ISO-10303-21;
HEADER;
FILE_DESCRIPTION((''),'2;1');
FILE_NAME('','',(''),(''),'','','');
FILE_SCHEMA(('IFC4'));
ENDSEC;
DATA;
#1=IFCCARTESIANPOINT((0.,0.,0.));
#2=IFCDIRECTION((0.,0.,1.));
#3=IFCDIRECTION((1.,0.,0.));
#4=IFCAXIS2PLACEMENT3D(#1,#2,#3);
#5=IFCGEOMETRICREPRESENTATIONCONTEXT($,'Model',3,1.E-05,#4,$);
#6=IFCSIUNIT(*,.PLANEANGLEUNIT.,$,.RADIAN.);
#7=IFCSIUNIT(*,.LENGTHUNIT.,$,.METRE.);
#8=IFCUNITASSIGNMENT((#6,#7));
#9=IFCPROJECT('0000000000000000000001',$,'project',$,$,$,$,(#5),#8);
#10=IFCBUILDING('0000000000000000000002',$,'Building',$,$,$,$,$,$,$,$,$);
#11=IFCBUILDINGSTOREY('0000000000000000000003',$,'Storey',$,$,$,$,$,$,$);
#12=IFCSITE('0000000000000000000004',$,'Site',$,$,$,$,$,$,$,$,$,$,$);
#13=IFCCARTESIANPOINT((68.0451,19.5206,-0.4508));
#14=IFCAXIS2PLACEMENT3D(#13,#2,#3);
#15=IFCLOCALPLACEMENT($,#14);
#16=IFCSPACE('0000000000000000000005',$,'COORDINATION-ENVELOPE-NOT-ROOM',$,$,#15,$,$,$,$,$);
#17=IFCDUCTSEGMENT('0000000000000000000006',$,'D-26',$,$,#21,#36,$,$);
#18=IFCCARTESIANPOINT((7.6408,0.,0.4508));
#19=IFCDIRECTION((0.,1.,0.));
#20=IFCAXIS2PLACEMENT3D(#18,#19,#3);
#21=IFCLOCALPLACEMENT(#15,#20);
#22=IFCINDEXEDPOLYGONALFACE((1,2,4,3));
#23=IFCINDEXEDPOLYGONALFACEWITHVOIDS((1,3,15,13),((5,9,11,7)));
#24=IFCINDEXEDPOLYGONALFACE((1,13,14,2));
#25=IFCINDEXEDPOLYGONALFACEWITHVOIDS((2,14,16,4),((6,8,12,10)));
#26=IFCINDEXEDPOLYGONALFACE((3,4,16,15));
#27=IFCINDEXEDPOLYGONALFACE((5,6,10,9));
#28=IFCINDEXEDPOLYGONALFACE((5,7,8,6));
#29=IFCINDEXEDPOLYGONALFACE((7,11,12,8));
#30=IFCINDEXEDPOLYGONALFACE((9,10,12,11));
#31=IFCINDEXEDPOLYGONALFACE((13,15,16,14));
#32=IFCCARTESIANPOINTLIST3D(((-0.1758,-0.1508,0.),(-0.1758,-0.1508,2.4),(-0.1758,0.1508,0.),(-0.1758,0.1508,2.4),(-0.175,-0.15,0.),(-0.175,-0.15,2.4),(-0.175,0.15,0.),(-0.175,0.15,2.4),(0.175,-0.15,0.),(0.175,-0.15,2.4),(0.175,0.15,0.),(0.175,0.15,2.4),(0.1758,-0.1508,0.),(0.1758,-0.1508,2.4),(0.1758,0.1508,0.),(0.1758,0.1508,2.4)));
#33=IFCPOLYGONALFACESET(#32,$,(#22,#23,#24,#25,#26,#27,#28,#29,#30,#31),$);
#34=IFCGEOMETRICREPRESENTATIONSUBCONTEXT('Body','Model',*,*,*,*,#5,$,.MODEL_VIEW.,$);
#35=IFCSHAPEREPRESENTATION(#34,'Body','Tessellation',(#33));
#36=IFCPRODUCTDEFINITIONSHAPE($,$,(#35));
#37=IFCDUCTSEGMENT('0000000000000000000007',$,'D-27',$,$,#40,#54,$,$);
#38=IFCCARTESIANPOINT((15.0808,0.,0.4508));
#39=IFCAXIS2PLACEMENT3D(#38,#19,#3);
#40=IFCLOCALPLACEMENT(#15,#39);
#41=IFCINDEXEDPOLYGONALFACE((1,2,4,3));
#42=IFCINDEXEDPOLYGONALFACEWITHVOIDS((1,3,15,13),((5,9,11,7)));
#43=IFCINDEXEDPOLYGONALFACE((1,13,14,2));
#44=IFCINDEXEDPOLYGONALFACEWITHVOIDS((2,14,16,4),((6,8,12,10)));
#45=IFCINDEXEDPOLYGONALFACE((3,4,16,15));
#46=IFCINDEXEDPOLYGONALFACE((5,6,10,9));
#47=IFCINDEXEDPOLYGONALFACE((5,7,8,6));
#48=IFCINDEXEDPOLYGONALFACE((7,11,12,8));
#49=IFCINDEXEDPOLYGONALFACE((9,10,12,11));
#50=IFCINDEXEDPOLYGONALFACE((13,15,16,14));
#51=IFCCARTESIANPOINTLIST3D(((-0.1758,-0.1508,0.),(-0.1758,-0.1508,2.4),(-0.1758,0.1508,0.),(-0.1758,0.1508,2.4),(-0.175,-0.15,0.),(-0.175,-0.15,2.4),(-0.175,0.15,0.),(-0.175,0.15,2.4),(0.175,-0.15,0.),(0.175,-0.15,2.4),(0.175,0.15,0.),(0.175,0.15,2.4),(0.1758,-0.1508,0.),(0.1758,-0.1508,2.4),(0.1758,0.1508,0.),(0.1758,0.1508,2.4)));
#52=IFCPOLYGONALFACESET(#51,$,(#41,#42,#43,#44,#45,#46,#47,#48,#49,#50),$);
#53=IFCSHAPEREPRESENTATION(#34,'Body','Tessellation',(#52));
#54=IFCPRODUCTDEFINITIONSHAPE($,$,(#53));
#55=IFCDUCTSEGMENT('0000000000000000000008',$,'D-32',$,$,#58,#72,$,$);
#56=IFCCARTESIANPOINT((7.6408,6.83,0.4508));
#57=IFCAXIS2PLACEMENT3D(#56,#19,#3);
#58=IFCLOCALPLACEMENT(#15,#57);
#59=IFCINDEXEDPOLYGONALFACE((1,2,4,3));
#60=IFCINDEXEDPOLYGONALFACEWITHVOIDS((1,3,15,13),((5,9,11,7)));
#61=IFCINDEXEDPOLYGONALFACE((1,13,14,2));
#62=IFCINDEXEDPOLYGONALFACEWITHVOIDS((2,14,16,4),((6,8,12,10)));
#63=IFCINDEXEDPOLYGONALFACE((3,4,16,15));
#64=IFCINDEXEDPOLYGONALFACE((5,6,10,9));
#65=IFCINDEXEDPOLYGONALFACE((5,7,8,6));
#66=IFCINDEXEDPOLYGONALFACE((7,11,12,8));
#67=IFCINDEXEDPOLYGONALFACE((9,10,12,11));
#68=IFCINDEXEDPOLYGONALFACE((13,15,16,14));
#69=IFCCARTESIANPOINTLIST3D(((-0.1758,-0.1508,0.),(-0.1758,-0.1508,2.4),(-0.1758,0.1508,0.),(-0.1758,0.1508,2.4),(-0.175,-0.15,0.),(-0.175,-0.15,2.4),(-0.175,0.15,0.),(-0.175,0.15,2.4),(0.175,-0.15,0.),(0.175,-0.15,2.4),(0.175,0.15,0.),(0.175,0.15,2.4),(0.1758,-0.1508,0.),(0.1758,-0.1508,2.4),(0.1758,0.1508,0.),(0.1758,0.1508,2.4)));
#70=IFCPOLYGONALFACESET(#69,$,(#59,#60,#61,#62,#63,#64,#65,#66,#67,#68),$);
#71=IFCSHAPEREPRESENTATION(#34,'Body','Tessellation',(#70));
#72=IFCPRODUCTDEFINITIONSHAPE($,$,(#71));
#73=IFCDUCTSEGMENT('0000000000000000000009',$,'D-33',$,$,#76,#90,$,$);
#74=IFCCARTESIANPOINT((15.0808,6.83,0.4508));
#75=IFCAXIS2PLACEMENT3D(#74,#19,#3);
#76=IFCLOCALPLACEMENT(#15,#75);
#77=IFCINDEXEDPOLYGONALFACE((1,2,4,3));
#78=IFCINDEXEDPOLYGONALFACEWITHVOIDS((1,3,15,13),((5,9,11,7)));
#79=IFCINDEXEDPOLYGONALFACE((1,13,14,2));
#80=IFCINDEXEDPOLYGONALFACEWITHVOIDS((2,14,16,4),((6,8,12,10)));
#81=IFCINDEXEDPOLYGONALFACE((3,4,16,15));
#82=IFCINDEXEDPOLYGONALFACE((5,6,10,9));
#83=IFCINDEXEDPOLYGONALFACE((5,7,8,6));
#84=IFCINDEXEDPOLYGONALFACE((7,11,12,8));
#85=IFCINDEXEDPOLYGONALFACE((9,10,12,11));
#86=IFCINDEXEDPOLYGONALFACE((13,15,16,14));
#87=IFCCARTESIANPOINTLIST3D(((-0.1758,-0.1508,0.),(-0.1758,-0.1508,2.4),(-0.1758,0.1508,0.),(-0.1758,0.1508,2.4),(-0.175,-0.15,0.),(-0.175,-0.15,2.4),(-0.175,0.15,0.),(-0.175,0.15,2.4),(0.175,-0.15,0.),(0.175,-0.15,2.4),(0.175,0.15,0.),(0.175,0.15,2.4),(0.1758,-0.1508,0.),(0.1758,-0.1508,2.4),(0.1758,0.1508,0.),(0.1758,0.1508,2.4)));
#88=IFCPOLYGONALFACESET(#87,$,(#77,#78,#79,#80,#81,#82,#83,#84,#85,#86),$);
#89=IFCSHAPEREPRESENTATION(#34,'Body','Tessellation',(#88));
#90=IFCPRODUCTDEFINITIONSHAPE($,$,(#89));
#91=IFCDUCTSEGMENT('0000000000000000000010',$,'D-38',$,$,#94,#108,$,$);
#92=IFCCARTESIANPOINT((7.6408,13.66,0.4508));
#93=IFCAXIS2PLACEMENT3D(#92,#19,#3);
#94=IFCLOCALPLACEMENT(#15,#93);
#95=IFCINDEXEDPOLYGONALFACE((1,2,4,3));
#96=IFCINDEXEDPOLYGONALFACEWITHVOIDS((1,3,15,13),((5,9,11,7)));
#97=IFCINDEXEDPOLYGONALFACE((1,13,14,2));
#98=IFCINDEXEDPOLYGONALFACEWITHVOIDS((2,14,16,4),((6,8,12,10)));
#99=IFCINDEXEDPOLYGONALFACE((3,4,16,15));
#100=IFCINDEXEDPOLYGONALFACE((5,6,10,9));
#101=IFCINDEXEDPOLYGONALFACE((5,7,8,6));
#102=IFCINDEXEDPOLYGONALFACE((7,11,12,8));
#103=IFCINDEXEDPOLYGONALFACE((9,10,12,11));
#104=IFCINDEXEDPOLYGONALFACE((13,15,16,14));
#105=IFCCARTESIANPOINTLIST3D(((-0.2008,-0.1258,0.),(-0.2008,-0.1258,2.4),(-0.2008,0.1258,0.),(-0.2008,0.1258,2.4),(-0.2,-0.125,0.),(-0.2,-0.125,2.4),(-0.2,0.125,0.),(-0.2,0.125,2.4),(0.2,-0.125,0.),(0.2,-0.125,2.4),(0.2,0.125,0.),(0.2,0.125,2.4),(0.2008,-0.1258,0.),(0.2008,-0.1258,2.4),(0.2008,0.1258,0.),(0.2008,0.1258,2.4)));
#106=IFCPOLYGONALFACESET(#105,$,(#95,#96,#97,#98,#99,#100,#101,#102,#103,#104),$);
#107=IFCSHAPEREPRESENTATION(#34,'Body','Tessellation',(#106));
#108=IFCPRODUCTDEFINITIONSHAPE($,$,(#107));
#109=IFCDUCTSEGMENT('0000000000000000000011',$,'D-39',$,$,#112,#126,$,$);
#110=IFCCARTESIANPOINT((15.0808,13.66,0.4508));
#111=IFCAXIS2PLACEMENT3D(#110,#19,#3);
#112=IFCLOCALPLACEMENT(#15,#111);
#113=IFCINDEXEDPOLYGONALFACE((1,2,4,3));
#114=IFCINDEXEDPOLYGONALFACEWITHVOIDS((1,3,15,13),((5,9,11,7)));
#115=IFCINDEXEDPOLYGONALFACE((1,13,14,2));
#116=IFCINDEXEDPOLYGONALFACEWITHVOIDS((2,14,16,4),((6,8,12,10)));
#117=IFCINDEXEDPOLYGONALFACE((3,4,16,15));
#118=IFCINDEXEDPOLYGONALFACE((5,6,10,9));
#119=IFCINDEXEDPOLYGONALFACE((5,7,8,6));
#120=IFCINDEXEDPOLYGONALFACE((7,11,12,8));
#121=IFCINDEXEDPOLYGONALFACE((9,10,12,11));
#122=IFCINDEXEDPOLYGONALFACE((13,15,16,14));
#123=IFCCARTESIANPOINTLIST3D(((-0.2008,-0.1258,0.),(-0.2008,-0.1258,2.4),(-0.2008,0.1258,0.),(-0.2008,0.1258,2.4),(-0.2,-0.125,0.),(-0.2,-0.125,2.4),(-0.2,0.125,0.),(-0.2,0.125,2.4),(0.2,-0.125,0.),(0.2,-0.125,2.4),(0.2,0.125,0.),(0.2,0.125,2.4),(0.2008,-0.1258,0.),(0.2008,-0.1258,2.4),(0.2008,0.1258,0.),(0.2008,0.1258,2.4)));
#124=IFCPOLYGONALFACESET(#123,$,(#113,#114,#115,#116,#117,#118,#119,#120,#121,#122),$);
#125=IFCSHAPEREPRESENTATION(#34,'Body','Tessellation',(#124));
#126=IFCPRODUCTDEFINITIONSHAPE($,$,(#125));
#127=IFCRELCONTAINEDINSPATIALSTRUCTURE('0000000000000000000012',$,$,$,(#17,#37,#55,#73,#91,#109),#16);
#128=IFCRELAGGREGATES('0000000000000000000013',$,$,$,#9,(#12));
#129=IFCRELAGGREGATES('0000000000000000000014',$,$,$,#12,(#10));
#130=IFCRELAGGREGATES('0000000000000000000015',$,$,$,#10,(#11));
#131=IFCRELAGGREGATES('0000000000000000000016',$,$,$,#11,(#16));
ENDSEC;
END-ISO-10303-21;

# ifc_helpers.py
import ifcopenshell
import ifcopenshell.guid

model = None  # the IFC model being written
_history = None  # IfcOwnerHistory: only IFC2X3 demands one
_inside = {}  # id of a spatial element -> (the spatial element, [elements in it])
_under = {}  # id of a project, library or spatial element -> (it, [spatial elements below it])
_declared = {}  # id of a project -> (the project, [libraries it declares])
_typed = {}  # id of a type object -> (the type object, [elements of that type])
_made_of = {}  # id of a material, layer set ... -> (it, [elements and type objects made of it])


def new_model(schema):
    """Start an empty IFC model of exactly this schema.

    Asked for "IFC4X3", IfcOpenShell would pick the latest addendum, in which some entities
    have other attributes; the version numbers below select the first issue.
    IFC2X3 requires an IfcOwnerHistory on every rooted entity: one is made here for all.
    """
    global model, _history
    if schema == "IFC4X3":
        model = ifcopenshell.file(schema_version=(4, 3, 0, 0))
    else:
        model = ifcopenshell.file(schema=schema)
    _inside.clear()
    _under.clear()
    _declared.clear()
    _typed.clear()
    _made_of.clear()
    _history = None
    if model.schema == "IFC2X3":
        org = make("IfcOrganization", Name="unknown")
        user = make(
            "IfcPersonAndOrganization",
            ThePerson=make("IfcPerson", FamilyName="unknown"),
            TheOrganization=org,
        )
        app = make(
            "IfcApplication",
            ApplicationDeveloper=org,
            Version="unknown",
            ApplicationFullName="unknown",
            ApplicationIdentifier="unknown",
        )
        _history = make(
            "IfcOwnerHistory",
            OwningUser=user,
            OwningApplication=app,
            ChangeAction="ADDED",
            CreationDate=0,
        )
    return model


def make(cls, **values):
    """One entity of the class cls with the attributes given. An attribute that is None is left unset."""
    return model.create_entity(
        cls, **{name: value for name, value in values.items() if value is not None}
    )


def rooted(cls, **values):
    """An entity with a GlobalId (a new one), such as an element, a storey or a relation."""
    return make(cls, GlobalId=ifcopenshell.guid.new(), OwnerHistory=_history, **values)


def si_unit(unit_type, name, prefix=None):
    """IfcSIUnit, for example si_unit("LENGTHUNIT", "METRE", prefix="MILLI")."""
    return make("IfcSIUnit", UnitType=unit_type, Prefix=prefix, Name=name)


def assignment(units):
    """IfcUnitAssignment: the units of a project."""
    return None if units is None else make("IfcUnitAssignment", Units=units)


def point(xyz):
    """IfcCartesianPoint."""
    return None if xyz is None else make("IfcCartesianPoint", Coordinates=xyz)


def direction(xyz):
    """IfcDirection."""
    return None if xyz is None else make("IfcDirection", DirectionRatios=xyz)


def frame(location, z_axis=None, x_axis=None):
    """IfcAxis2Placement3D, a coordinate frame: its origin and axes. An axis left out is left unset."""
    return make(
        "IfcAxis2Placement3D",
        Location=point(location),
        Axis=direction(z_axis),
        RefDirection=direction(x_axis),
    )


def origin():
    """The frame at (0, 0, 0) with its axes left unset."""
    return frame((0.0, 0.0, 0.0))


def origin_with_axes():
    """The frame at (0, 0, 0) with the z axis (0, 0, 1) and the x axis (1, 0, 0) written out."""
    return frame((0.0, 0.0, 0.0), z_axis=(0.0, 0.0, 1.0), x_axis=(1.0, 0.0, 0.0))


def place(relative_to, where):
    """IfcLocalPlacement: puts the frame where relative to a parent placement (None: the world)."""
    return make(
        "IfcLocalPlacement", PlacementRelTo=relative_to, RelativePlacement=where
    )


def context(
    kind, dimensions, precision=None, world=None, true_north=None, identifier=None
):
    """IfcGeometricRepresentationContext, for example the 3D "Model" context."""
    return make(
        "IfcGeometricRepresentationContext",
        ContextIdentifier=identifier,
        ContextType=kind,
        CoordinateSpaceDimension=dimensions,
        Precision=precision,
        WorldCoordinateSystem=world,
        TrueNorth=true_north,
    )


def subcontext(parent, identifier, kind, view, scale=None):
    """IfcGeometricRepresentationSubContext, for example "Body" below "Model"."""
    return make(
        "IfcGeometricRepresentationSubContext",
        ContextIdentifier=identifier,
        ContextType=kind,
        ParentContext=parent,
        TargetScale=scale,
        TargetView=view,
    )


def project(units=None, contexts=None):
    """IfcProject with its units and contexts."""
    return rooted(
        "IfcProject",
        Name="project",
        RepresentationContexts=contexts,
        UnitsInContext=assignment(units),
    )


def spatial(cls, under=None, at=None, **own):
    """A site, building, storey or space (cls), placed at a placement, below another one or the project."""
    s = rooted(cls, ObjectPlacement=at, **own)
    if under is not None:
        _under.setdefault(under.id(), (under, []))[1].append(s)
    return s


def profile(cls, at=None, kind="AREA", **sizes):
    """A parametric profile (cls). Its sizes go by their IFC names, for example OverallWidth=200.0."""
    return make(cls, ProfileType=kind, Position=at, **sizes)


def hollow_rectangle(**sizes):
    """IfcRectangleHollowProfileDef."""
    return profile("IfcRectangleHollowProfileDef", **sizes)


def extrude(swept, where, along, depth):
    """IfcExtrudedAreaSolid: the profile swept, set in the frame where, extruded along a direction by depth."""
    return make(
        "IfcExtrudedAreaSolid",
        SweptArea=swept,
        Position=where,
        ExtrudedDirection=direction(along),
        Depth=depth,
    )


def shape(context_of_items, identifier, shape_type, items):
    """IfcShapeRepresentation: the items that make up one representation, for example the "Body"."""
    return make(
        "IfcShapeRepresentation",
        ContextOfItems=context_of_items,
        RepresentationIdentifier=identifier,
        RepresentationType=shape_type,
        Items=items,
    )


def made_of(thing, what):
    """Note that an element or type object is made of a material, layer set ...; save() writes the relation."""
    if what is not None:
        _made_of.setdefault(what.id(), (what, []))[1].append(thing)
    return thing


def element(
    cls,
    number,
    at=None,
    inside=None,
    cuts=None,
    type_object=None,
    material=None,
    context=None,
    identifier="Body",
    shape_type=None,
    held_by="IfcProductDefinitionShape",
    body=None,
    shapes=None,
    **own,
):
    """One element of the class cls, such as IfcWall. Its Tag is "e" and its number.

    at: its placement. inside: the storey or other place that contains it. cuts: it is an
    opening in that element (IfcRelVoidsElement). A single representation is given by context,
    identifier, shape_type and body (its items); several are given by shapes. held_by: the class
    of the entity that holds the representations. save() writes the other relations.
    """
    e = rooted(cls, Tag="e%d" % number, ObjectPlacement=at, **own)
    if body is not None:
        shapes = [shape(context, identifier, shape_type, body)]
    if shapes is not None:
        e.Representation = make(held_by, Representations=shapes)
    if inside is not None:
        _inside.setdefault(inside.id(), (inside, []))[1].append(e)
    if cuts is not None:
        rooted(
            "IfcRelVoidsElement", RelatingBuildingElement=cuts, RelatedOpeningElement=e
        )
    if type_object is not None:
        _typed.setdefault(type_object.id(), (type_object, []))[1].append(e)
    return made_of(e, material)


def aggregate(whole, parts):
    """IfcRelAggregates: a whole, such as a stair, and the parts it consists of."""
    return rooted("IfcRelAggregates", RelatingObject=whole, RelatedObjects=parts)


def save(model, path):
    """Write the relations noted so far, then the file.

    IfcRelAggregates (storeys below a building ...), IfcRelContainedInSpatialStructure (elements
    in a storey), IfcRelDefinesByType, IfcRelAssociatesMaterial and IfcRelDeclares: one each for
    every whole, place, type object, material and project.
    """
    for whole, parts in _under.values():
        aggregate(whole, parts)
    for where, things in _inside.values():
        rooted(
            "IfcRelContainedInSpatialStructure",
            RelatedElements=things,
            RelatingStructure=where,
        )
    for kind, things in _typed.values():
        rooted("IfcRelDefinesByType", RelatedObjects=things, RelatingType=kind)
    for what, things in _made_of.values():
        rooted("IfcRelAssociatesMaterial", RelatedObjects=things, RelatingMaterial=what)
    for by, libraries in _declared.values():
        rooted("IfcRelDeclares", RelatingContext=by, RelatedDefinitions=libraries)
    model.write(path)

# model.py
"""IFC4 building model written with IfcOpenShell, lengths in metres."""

from ifc_helpers import new_model, si_unit, frame, origin, origin_with_axes, place, context, subcontext, project, spatial, hollow_rectangle, extrude, element, save


model = new_model("IFC4")

# Units and contexts
model_context = context("Model", 3, precision=1e-05, world=origin_with_axes())
body_context = subcontext(model_context, "Body", "Model", "MODEL_VIEW")
ifc_project = project(units=[si_unit("PLANEANGLEUNIT", "RADIAN"), si_unit("LENGTHUNIT", "METRE")], contexts=[model_context])

# Site, building, storey, space
site = spatial("IfcSite", under=ifc_project, Name="Site")
building = spatial("IfcBuilding", under=site, Name="Building")
storey = spatial("IfcBuildingStorey", under=building, Name="Storey")
space_placement = place(None, frame((68.0451, 19.5206, -0.4508), z_axis=(0.0, 0.0, 1.0), x_axis=(1.0, 0.0, 0.0)))
space = spatial("IfcSpace", under=storey, at=space_placement, Name="COORDINATION-ENVELOPE-NOT-ROOM")

# Duct segments
for number, where, z_axis, x_axis, name in (
    (1, (7.6408, 0.0, 0.4508), (0.0, 1.0, 0.0), (1.0, 0.0, 0.0), "D-26"),
    (2, (15.0808, 0.0, 0.4508), (0.0, 1.0, 0.0), (1.0, 0.0, 0.0), "D-27"),
):
    element("IfcDuctSegment", number, at=place(space_placement, frame(where, z_axis=z_axis, x_axis=x_axis)), inside=space, Name=name, context=body_context, shape_type="SweptSolid", body=[
        extrude(hollow_rectangle(XDim=0.3516, YDim=0.3016, WallThickness=0.0008), origin(), (0.0, 0.0, 1.0), 2.4),
    ])
for number, where, z_axis, x_axis, name in (
    (3, (7.6408, 6.83, 0.4508), (0.0, 1.0, 0.0), (1.0, 0.0, 0.0), "D-32"),
    (4, (15.0808, 6.83, 0.4508), (0.0, 1.0, 0.0), (1.0, 0.0, 0.0), "D-33"),
):
    element("IfcDuctSegment", number, at=place(space_placement, frame(where, z_axis=z_axis, x_axis=x_axis)), inside=space, Name=name, context=body_context, shape_type="SweptSolid", body=[
        extrude(hollow_rectangle(XDim=0.3516, YDim=0.3016, WallThickness=0.0008), origin(), (0.0, 0.0, 1.0), 2.4),
    ])
for number, where, z_axis, x_axis, name in (
    (5, (7.6408, 13.66, 0.4508), (0.0, 1.0, 0.0), (1.0, 0.0, 0.0), "D-38"),
    (6, (15.0808, 13.66, 0.4508), (0.0, 1.0, 0.0), (1.0, 0.0, 0.0), "D-39"),
):
    element("IfcDuctSegment", number, at=place(space_placement, frame(where, z_axis=z_axis, x_axis=x_axis)), inside=space, Name=name, context=body_context, shape_type="SweptSolid", body=[
        extrude(hollow_rectangle(XDim=0.4016, YDim=0.2516, WallThickness=0.0008), origin(), (0.0, 0.0, 1.0), 2.4),
    ])

save(model, "model.ifc")
